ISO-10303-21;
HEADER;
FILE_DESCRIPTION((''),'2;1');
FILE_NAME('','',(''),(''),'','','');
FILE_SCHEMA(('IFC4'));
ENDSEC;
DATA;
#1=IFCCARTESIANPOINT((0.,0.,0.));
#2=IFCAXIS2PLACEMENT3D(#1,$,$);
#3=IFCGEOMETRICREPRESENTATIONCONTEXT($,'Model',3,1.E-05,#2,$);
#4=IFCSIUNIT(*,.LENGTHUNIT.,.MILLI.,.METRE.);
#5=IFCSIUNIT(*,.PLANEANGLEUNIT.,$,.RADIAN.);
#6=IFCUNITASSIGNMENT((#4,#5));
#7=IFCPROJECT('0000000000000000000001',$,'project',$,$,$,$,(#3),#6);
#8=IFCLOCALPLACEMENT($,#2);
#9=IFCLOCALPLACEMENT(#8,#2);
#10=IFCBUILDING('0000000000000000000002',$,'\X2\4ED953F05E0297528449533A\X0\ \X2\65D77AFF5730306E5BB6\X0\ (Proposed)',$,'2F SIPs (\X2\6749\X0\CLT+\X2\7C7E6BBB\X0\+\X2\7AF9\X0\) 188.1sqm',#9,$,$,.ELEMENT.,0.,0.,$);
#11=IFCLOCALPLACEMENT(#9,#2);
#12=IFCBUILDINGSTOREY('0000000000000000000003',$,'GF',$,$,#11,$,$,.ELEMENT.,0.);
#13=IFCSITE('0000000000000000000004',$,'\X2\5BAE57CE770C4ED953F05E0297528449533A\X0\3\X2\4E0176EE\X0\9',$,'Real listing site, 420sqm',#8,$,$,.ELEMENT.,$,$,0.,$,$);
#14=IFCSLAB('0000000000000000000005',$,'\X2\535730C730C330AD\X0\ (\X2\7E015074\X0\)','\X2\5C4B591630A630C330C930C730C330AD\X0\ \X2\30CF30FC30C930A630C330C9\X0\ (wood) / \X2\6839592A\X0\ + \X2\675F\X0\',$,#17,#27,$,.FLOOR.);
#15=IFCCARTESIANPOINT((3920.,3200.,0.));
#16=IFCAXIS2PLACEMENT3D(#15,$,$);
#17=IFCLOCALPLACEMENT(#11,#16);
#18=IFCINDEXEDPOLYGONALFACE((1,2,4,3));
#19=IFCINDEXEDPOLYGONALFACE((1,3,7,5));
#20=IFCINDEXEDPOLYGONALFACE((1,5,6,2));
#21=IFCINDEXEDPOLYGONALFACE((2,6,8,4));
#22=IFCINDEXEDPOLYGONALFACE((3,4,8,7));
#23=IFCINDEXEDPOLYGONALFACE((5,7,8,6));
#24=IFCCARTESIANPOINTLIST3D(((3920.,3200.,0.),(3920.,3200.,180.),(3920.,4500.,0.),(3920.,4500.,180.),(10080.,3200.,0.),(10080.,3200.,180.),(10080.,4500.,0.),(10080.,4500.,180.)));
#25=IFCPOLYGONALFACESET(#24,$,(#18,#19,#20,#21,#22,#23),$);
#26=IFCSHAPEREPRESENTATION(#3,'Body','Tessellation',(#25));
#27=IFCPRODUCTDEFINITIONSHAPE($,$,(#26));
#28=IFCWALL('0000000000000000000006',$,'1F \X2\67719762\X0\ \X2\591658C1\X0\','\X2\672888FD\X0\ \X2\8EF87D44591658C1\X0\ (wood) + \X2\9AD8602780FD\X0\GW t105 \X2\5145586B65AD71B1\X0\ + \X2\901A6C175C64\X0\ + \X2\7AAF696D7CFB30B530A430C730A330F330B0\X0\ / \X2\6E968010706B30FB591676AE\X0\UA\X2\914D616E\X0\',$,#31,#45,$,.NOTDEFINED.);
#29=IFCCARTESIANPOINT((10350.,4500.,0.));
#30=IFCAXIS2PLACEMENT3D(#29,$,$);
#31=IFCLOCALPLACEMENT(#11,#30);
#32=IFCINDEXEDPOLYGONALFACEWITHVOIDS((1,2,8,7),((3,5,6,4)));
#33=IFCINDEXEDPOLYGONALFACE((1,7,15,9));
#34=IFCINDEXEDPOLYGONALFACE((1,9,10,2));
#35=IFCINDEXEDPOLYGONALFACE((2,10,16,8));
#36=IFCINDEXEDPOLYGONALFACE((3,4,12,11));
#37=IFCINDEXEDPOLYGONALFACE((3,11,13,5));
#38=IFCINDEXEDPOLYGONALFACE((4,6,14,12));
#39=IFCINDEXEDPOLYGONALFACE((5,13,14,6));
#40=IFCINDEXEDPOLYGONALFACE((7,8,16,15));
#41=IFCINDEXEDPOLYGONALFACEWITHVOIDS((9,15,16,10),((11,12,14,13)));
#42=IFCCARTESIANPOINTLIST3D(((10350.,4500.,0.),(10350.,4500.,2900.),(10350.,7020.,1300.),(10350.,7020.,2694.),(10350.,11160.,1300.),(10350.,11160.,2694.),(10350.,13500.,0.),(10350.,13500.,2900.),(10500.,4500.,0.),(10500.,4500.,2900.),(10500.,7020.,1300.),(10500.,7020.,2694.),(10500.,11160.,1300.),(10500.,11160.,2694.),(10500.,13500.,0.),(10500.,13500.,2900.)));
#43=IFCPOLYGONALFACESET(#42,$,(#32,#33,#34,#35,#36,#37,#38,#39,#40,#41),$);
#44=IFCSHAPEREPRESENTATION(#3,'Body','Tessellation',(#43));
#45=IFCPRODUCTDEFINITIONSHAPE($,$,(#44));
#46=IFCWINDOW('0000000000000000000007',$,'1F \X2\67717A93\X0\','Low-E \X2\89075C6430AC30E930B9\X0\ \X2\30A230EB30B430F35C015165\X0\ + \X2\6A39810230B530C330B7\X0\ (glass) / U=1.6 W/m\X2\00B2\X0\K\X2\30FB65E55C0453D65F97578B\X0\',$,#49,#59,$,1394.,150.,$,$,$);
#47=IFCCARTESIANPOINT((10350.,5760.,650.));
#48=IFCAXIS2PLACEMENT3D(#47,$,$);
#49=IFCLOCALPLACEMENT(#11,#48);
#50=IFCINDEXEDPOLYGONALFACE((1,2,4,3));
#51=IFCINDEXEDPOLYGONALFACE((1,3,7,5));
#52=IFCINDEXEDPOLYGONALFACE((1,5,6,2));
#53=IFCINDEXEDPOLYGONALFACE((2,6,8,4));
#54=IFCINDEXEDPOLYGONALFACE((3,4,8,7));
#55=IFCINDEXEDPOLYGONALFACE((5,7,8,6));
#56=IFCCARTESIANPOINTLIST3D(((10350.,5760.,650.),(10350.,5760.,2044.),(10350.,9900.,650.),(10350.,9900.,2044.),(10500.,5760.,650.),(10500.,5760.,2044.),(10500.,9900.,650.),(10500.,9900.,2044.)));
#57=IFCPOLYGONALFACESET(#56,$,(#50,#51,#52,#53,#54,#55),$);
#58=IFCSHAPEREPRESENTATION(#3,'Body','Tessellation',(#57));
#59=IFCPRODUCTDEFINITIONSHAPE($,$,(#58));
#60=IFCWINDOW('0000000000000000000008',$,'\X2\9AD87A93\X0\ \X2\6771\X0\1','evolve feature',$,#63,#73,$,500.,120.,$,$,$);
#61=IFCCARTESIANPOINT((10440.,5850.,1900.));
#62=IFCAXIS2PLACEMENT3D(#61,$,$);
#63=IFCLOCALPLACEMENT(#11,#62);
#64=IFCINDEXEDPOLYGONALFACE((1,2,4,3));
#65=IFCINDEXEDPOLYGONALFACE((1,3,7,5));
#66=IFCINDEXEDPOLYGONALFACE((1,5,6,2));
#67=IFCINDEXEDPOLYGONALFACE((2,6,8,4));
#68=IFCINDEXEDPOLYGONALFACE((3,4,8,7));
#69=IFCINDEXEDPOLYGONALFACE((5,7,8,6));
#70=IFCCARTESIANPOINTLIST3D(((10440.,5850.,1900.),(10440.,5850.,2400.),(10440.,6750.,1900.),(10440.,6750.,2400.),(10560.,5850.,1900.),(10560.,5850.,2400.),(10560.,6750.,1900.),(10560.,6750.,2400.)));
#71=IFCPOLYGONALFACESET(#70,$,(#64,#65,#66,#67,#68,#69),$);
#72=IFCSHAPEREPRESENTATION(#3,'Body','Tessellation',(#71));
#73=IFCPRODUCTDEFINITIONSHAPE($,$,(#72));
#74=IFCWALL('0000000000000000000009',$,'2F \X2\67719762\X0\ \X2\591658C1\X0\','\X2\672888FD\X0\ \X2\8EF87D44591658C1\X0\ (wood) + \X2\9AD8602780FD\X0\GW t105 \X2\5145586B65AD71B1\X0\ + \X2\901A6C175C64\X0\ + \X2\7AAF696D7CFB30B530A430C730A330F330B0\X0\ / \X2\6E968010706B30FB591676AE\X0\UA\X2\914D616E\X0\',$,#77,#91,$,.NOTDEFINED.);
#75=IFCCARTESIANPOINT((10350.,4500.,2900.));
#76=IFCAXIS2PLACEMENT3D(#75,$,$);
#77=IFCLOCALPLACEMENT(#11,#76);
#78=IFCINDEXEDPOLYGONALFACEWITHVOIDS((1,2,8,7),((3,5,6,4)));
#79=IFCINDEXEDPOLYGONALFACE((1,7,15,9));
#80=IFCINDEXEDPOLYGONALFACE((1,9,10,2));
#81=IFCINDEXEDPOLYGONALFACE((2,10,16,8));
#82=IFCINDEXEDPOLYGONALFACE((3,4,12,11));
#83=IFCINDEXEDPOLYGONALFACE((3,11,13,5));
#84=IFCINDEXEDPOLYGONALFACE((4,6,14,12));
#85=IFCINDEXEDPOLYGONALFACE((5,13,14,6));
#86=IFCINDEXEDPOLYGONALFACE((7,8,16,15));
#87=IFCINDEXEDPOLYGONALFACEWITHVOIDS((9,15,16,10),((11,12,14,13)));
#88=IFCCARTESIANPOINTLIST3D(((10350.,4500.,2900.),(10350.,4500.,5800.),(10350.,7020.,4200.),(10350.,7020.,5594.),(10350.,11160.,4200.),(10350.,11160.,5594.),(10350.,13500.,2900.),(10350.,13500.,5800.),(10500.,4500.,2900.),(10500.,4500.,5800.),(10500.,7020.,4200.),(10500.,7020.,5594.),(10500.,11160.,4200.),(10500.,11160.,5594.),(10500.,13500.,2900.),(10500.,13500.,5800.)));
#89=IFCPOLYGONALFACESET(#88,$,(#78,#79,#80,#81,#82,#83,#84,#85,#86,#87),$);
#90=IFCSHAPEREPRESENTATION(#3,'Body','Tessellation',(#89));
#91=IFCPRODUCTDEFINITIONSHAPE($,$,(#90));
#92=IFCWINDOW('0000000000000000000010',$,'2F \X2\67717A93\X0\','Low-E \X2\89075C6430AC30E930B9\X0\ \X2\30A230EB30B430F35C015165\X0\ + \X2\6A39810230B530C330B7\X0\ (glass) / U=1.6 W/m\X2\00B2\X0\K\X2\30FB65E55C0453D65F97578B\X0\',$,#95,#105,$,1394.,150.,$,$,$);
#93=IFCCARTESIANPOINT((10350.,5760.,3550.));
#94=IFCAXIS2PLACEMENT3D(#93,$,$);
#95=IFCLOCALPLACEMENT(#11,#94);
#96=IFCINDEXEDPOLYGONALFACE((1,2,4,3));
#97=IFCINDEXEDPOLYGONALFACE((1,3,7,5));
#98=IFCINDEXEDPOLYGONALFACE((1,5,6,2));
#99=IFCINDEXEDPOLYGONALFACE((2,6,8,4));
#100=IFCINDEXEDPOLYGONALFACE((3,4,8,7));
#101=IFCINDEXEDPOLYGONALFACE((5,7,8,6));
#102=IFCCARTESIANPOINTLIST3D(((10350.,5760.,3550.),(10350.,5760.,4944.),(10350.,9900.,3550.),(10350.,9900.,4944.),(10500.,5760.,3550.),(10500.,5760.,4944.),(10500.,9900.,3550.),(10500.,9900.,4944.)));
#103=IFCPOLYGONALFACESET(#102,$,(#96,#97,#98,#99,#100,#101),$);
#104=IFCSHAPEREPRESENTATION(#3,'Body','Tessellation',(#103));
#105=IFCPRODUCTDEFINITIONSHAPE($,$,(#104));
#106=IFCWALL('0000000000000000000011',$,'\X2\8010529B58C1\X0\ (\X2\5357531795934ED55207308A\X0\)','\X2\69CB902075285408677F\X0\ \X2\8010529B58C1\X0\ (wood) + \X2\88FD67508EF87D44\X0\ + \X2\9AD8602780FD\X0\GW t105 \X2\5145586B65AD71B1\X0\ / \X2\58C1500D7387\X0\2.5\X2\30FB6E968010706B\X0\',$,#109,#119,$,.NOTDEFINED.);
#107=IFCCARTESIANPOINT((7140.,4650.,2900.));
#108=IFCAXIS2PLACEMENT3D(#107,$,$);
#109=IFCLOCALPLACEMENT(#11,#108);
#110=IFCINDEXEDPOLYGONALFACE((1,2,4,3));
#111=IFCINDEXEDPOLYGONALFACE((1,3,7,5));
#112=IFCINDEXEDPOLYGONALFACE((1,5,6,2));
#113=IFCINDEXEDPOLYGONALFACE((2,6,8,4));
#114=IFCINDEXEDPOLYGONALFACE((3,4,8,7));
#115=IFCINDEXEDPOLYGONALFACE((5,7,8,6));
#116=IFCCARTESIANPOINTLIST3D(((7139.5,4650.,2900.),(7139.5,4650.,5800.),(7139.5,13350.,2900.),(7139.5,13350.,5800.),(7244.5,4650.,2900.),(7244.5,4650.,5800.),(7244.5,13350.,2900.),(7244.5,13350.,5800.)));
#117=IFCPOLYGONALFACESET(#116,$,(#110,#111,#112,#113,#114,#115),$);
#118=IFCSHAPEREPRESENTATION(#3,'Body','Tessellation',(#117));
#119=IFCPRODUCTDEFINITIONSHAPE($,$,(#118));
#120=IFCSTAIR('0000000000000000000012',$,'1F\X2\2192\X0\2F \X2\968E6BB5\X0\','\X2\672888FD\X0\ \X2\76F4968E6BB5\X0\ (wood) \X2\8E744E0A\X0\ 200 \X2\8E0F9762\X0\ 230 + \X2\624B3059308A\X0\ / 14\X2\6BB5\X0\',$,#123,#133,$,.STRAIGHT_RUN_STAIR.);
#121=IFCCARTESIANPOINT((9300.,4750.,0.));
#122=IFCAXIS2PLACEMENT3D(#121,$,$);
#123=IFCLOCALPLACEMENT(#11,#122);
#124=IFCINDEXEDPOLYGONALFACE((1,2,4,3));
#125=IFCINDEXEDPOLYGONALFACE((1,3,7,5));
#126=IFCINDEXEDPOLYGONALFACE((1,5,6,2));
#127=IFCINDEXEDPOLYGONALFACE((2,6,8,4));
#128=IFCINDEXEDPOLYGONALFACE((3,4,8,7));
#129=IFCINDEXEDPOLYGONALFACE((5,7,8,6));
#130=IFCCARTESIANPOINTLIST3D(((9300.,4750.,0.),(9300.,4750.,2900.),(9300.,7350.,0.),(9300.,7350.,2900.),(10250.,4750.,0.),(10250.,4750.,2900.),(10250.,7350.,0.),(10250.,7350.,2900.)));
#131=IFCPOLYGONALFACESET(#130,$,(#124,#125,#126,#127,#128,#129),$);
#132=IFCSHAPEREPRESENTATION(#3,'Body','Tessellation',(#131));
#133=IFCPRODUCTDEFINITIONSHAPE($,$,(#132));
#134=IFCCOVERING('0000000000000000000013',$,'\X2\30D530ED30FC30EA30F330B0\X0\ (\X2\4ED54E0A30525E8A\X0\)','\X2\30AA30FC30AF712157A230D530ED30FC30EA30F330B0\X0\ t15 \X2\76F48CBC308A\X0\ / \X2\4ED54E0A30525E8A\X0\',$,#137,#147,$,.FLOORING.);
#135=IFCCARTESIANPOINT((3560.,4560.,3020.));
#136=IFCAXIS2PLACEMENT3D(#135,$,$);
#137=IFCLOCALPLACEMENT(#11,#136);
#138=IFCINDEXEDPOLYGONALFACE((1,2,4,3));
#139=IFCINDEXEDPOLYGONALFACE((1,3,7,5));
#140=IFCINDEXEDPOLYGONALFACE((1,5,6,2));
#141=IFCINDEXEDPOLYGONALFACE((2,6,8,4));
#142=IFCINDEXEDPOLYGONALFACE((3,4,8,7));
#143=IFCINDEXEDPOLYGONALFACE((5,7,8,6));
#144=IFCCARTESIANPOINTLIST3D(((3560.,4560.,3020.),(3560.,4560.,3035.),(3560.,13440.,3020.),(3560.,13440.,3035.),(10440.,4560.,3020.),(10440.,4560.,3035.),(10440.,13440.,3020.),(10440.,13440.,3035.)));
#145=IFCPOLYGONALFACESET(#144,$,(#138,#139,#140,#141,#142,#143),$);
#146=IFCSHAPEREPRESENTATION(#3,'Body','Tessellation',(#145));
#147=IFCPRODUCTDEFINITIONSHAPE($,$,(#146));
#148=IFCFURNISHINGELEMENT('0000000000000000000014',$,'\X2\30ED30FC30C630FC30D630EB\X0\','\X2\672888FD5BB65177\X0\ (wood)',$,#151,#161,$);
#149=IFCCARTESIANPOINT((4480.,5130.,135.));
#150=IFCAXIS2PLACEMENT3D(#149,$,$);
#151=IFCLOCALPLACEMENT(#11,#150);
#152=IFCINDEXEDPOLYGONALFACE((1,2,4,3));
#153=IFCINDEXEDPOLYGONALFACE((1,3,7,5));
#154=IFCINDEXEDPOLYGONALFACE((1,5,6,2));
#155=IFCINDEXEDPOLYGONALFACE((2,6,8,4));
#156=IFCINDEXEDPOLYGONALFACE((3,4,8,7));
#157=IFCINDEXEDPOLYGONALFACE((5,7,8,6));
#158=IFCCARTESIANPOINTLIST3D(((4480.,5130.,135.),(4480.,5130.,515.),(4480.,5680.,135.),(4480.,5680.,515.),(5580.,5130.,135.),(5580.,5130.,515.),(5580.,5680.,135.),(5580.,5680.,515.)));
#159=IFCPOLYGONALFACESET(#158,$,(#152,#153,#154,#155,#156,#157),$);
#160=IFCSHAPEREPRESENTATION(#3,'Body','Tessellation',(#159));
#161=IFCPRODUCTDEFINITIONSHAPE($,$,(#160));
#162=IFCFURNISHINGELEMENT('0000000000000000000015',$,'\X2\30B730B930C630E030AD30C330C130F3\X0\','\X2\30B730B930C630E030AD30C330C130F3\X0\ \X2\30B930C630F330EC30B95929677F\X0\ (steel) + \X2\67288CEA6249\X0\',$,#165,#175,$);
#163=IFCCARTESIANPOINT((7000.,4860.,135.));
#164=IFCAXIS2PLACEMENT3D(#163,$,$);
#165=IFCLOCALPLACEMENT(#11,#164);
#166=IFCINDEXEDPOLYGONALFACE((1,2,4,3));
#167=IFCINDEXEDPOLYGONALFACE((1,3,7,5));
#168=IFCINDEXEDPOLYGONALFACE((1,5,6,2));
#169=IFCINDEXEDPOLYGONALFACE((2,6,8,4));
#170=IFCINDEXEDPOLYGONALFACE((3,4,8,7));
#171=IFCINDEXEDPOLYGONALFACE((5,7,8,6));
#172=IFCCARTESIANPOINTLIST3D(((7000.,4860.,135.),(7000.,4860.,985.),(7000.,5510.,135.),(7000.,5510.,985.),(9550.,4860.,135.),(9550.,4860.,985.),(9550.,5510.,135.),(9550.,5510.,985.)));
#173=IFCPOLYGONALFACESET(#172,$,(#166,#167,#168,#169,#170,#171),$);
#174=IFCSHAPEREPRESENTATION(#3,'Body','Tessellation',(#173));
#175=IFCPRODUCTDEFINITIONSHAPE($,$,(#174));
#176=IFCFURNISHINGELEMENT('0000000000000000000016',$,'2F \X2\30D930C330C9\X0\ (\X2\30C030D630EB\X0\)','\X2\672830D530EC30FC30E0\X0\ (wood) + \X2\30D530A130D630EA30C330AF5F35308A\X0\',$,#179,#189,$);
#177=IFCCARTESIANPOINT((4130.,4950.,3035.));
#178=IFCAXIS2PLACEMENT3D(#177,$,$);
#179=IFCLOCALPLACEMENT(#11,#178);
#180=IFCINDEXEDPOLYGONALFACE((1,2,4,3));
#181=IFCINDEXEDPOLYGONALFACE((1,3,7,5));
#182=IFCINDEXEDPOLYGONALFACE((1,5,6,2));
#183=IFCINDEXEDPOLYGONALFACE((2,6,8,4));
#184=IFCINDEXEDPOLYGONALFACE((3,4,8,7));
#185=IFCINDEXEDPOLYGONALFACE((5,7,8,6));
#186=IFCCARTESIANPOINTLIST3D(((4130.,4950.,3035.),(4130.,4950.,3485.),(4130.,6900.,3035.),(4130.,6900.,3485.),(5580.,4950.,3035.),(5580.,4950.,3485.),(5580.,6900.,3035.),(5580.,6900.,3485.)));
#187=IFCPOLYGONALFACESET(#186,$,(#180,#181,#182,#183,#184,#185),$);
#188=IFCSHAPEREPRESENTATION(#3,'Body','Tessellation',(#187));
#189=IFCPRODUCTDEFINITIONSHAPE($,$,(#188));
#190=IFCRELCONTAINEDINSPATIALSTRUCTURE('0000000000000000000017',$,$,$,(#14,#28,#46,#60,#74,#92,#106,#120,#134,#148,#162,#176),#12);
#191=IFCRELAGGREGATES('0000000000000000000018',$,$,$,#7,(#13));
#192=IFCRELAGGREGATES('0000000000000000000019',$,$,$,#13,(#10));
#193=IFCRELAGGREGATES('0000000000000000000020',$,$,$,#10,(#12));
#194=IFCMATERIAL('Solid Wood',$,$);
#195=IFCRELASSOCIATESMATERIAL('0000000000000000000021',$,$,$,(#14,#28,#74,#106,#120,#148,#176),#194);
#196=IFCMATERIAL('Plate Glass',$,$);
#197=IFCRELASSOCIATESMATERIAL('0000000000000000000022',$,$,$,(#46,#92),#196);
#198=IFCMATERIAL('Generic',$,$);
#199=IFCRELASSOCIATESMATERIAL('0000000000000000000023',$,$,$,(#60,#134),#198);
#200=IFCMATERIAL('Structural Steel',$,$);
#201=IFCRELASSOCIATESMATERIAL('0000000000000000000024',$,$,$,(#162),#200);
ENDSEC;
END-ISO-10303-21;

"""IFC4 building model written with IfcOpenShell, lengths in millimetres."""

from ifc_helpers import new_model, si_unit, frame, frame_2d, origin, place, context, project, spatial, rectangle, extrude, material, element, fill, save


model = new_model("IFC4")

# Units and contexts
model_context = context("Model", 3, precision=1e-05, world=origin())
ifc_project = project(units=[si_unit("LENGTHUNIT", "METRE", prefix="MILLI"), si_unit("PLANEANGLEUNIT", "RADIAN")], contexts=[model_context])

# Site, building, storey
site_placement = place(None, origin())
site = spatial("IfcSite", under=ifc_project, at=site_placement, Name="宮城県仙台市青葉区3丁目9", ObjectType="Real listing site, 420sqm", CompositionType="ELEMENT", RefElevation=0.0)
building_placement = place(site_placement, origin())
building = spatial("IfcBuilding", under=site, at=building_placement, Name="仙台市青葉区 旗竿地の家 (Proposed)", ObjectType="2F SIPs (杉CLT+籾殻+竹) 188.1sqm", CompositionType="ELEMENT", ElevationOfRefHeight=0.0, ElevationOfTerrain=0.0)
storey_placement = place(building_placement, origin())
storey = spatial("IfcBuildingStorey", under=building, at=storey_placement, Name="GF", CompositionType="ELEMENT", Elevation=0.0)

# Slab
ifc_material_1 = material(Name="Solid Wood")
slab_placement = place(storey_placement, frame((3920.0, 3200.0, 0.0)))
element("IfcSlab", 1, at=slab_placement, inside=storey, material=ifc_material_1, Name="南デッキ (縁側)", Description="屋外ウッドデッキ ハードウッド (wood) / 根太 + 束", PredefinedType="FLOOR", context=model_context, shape_type="SweptSolid", body=[
    extrude(rectangle(XDim=6160.0, YDim=1300.0, at=frame_2d((3080.0, 650.0))), frame((3920.0, 3200.0, 0.0)), (0.0, 0.0, 1.0), 180.0),
])

# Wall, openings, windows
wall_1_placement = place(storey_placement, frame((10350.0, 4500.0, 0.0)))
wall_1 = element("IfcWall", 2, at=wall_1_placement, inside=storey, material=ifc_material_1, Name="1F 東面 外壁", Description="木製 軸組外壁 (wood) + 高性能GW t105 充填断熱 + 通気層 + 窯業系サイディング / 準耐火・外皮UA配慮", PredefinedType="NOTDEFINED", context=model_context, shape_type="SweptSolid", body=[
    extrude(rectangle(XDim=150.0, YDim=9000.0, at=frame_2d((75.0, 4500.0))), frame((10350.0, 4500.0, 0.0)), (0.0, 0.0, 1.0), 2900.0),
])
opening_1_placement = place(storey_placement, frame((10350.0, 5760.0, 650.0)))
opening_1 = element("IfcOpeningElement", 3, at=opening_1_placement, cuts=wall_1, PredefinedType="NOTDEFINED", context=model_context, shape_type="SweptSolid", body=[
    extrude(rectangle(XDim=150.0, YDim=4140.0, at=frame_2d((75.0, 2070.0))), frame((10350.0, 5760.0, 650.0)), (0.0, 0.0, 1.0), 1394.0),
])
opening_2_placement = place(storey_placement, frame((10440.0, 5850.0, 1900.0)))
opening_2 = element("IfcOpeningElement", 4, at=opening_2_placement, cuts=wall_1, PredefinedType="NOTDEFINED", context=model_context, shape_type="SweptSolid", body=[
    extrude(rectangle(XDim=120.0, YDim=900.0, at=frame_2d((60.0, 450.0))), frame((10440.0, 5850.0, 1900.0)), (0.0, 0.0, 1.0), 500.0),
])
ifc_material_2 = material(Name="Plate Glass")
window_1_placement = place(storey_placement, frame((10350.0, 5760.0, 650.0)))
window_1 = element("IfcWindow", 5, at=window_1_placement, inside=storey, material=ifc_material_2, Name="1F 東窓", Description="Low-E 複層ガラス アルゴン封入 + 樹脂サッシ (glass) / U=1.6 W/m²K・日射取得型", OverallHeight=1394.0, OverallWidth=150.0, context=model_context, shape_type="SweptSolid", body=[
    extrude(rectangle(XDim=150.0, YDim=4140.0, at=frame_2d((75.0, 2070.0))), frame((10350.0, 5760.0, 650.0)), (0.0, 0.0, 1.0), 1394.0),
])
fill(opening_1, window_1)
ifc_material_3 = material(Name="Generic")
window_2_placement = place(storey_placement, frame((10440.0, 5850.0, 1900.0)))
window_2 = element("IfcWindow", 6, at=window_2_placement, inside=storey, material=ifc_material_3, Name="高窓 東1", Description="evolve feature", OverallHeight=500.0, OverallWidth=120.0, context=model_context, shape_type="SweptSolid", body=[
    extrude(rectangle(XDim=120.0, YDim=900.0, at=frame_2d((60.0, 450.0))), frame((10440.0, 5850.0, 1900.0)), (0.0, 0.0, 1.0), 500.0),
])
fill(opening_2, window_2)

# Wall, opening, window
wall_2_placement = place(storey_placement, frame((10350.0, 4500.0, 2900.0)))
wall_2 = element("IfcWall", 7, at=wall_2_placement, inside=storey, material=ifc_material_1, Name="2F 東面 外壁", Description="木製 軸組外壁 (wood) + 高性能GW t105 充填断熱 + 通気層 + 窯業系サイディング / 準耐火・外皮UA配慮", PredefinedType="NOTDEFINED", context=model_context, shape_type="SweptSolid", body=[
    extrude(rectangle(XDim=150.0, YDim=9000.0, at=frame_2d((75.0, 4500.0))), frame((10350.0, 4500.0, 2900.0)), (0.0, 0.0, 1.0), 2900.0),
])
opening_3_placement = place(storey_placement, frame((10350.0, 5760.0, 3550.0)))
opening_3 = element("IfcOpeningElement", 8, at=opening_3_placement, cuts=wall_2, PredefinedType="NOTDEFINED", context=model_context, shape_type="SweptSolid", body=[
    extrude(rectangle(XDim=150.0, YDim=4140.0, at=frame_2d((75.0, 2070.0))), frame((10350.0, 5760.0, 3550.0)), (0.0, 0.0, 1.0), 1394.0),
])
window_3_placement = place(storey_placement, frame((10350.0, 5760.0, 3550.0)))
window_3 = element("IfcWindow", 9, at=window_3_placement, inside=storey, material=ifc_material_2, Name="2F 東窓", Description="Low-E 複層ガラス アルゴン封入 + 樹脂サッシ (glass) / U=1.6 W/m²K・日射取得型", OverallHeight=1394.0, OverallWidth=150.0, context=model_context, shape_type="SweptSolid", body=[
    extrude(rectangle(XDim=150.0, YDim=4140.0, at=frame_2d((75.0, 2070.0))), frame((10350.0, 5760.0, 3550.0)), (0.0, 0.0, 1.0), 1394.0),
])
fill(opening_3, window_3)

# Wall
wall_3_placement = place(storey_placement, frame((7140.0, 4650.0, 2900.0)))
element("IfcWall", 10, at=wall_3_placement, inside=storey, material=ifc_material_1, Name="耐力壁 (南北間仕切り)", Description="構造用合板 耐力壁 (wood) + 製材軸組 + 高性能GW t105 充填断熱 / 壁倍率2.5・準耐火", PredefinedType="NOTDEFINED", context=model_context, shape_type="SweptSolid", body=[
    extrude(rectangle(XDim=105.0, YDim=8700.0, at=frame_2d((52.0, 4350.0))), frame((7140.0, 4650.0, 2900.0)), (0.0, 0.0, 1.0), 2900.0),
])

# Stair
stair_placement = place(storey_placement, frame((9300.0, 4750.0, 0.0)))
element("IfcStair", 11, at=stair_placement, inside=storey, material=ifc_material_1, Name="1F→2F 階段", Description="木製 直階段 (wood) 蹴上 200 踏面 230 + 手すり / 14段", PredefinedType="STRAIGHT_RUN_STAIR", context=model_context, shape_type="SweptSolid", body=[
    extrude(rectangle(XDim=950.0, YDim=2600.0, at=frame_2d((475.0, 1300.0))), frame((9300.0, 4750.0, 0.0)), (0.0, 0.0, 1.0), 2900.0),
])

# Covering
covering_placement = place(storey_placement, frame((3560.0, 4560.0, 3020.0)))
element("IfcCovering", 12, at=covering_placement, inside=storey, material=ifc_material_3, Name="フローリング (仕上げ床)", Description="オーク無垢フローリング t15 直貼り / 仕上げ床", PredefinedType="FLOORING", context=model_context, shape_type="SweptSolid", body=[
    extrude(rectangle(XDim=6880.0, YDim=8880.0, at=frame_2d((3440.0, 4440.0))), frame((3560.0, 4560.0, 3020.0)), (0.0, 0.0, 1.0), 15.0),
])

# Furnishing elements
furnishing_1_placement = place(storey_placement, frame((4480.0, 5130.0, 135.0)))
element("IfcFurnishingElement", 13, at=furnishing_1_placement, inside=storey, material=ifc_material_1, Name="ローテーブル", Description="木製家具 (wood)", context=model_context, shape_type="SweptSolid", body=[
    extrude(rectangle(XDim=1100.0, YDim=550.0, at=frame_2d((550.0, 275.0))), frame((4480.0, 5130.0, 135.0)), (0.0, 0.0, 1.0), 380.0),
])
ifc_material_4 = material(Name="Structural Steel")
furnishing_2_placement = place(storey_placement, frame((7000.0, 4860.0, 135.0)))
element("IfcFurnishingElement", 14, at=furnishing_2_placement, inside=storey, material=ifc_material_4, Name="システムキッチン", Description="システムキッチン ステンレス天板 (steel) + 木質扉", context=model_context, shape_type="SweptSolid", body=[
    extrude(rectangle(XDim=2550.0, YDim=650.0, at=frame_2d((1275.0, 325.0))), frame((7000.0, 4860.0, 135.0)), (0.0, 0.0, 1.0), 850.0),
])
furnishing_3_placement = place(storey_placement, frame((4130.0, 4950.0, 3035.0)))
element("IfcFurnishingElement", 15, at=furnishing_3_placement, inside=storey, material=ifc_material_1, Name="2F ベッド (ダブル)", Description="木フレーム (wood) + ファブリック張り", context=model_context, shape_type="SweptSolid", body=[
    extrude(rectangle(XDim=1450.0, YDim=1950.0, at=frame_2d((725.0, 975.0))), frame((4130.0, 4950.0, 3035.0)), (0.0, 0.0, 1.0), 450.0),
])

save(model, "model.ifc")
